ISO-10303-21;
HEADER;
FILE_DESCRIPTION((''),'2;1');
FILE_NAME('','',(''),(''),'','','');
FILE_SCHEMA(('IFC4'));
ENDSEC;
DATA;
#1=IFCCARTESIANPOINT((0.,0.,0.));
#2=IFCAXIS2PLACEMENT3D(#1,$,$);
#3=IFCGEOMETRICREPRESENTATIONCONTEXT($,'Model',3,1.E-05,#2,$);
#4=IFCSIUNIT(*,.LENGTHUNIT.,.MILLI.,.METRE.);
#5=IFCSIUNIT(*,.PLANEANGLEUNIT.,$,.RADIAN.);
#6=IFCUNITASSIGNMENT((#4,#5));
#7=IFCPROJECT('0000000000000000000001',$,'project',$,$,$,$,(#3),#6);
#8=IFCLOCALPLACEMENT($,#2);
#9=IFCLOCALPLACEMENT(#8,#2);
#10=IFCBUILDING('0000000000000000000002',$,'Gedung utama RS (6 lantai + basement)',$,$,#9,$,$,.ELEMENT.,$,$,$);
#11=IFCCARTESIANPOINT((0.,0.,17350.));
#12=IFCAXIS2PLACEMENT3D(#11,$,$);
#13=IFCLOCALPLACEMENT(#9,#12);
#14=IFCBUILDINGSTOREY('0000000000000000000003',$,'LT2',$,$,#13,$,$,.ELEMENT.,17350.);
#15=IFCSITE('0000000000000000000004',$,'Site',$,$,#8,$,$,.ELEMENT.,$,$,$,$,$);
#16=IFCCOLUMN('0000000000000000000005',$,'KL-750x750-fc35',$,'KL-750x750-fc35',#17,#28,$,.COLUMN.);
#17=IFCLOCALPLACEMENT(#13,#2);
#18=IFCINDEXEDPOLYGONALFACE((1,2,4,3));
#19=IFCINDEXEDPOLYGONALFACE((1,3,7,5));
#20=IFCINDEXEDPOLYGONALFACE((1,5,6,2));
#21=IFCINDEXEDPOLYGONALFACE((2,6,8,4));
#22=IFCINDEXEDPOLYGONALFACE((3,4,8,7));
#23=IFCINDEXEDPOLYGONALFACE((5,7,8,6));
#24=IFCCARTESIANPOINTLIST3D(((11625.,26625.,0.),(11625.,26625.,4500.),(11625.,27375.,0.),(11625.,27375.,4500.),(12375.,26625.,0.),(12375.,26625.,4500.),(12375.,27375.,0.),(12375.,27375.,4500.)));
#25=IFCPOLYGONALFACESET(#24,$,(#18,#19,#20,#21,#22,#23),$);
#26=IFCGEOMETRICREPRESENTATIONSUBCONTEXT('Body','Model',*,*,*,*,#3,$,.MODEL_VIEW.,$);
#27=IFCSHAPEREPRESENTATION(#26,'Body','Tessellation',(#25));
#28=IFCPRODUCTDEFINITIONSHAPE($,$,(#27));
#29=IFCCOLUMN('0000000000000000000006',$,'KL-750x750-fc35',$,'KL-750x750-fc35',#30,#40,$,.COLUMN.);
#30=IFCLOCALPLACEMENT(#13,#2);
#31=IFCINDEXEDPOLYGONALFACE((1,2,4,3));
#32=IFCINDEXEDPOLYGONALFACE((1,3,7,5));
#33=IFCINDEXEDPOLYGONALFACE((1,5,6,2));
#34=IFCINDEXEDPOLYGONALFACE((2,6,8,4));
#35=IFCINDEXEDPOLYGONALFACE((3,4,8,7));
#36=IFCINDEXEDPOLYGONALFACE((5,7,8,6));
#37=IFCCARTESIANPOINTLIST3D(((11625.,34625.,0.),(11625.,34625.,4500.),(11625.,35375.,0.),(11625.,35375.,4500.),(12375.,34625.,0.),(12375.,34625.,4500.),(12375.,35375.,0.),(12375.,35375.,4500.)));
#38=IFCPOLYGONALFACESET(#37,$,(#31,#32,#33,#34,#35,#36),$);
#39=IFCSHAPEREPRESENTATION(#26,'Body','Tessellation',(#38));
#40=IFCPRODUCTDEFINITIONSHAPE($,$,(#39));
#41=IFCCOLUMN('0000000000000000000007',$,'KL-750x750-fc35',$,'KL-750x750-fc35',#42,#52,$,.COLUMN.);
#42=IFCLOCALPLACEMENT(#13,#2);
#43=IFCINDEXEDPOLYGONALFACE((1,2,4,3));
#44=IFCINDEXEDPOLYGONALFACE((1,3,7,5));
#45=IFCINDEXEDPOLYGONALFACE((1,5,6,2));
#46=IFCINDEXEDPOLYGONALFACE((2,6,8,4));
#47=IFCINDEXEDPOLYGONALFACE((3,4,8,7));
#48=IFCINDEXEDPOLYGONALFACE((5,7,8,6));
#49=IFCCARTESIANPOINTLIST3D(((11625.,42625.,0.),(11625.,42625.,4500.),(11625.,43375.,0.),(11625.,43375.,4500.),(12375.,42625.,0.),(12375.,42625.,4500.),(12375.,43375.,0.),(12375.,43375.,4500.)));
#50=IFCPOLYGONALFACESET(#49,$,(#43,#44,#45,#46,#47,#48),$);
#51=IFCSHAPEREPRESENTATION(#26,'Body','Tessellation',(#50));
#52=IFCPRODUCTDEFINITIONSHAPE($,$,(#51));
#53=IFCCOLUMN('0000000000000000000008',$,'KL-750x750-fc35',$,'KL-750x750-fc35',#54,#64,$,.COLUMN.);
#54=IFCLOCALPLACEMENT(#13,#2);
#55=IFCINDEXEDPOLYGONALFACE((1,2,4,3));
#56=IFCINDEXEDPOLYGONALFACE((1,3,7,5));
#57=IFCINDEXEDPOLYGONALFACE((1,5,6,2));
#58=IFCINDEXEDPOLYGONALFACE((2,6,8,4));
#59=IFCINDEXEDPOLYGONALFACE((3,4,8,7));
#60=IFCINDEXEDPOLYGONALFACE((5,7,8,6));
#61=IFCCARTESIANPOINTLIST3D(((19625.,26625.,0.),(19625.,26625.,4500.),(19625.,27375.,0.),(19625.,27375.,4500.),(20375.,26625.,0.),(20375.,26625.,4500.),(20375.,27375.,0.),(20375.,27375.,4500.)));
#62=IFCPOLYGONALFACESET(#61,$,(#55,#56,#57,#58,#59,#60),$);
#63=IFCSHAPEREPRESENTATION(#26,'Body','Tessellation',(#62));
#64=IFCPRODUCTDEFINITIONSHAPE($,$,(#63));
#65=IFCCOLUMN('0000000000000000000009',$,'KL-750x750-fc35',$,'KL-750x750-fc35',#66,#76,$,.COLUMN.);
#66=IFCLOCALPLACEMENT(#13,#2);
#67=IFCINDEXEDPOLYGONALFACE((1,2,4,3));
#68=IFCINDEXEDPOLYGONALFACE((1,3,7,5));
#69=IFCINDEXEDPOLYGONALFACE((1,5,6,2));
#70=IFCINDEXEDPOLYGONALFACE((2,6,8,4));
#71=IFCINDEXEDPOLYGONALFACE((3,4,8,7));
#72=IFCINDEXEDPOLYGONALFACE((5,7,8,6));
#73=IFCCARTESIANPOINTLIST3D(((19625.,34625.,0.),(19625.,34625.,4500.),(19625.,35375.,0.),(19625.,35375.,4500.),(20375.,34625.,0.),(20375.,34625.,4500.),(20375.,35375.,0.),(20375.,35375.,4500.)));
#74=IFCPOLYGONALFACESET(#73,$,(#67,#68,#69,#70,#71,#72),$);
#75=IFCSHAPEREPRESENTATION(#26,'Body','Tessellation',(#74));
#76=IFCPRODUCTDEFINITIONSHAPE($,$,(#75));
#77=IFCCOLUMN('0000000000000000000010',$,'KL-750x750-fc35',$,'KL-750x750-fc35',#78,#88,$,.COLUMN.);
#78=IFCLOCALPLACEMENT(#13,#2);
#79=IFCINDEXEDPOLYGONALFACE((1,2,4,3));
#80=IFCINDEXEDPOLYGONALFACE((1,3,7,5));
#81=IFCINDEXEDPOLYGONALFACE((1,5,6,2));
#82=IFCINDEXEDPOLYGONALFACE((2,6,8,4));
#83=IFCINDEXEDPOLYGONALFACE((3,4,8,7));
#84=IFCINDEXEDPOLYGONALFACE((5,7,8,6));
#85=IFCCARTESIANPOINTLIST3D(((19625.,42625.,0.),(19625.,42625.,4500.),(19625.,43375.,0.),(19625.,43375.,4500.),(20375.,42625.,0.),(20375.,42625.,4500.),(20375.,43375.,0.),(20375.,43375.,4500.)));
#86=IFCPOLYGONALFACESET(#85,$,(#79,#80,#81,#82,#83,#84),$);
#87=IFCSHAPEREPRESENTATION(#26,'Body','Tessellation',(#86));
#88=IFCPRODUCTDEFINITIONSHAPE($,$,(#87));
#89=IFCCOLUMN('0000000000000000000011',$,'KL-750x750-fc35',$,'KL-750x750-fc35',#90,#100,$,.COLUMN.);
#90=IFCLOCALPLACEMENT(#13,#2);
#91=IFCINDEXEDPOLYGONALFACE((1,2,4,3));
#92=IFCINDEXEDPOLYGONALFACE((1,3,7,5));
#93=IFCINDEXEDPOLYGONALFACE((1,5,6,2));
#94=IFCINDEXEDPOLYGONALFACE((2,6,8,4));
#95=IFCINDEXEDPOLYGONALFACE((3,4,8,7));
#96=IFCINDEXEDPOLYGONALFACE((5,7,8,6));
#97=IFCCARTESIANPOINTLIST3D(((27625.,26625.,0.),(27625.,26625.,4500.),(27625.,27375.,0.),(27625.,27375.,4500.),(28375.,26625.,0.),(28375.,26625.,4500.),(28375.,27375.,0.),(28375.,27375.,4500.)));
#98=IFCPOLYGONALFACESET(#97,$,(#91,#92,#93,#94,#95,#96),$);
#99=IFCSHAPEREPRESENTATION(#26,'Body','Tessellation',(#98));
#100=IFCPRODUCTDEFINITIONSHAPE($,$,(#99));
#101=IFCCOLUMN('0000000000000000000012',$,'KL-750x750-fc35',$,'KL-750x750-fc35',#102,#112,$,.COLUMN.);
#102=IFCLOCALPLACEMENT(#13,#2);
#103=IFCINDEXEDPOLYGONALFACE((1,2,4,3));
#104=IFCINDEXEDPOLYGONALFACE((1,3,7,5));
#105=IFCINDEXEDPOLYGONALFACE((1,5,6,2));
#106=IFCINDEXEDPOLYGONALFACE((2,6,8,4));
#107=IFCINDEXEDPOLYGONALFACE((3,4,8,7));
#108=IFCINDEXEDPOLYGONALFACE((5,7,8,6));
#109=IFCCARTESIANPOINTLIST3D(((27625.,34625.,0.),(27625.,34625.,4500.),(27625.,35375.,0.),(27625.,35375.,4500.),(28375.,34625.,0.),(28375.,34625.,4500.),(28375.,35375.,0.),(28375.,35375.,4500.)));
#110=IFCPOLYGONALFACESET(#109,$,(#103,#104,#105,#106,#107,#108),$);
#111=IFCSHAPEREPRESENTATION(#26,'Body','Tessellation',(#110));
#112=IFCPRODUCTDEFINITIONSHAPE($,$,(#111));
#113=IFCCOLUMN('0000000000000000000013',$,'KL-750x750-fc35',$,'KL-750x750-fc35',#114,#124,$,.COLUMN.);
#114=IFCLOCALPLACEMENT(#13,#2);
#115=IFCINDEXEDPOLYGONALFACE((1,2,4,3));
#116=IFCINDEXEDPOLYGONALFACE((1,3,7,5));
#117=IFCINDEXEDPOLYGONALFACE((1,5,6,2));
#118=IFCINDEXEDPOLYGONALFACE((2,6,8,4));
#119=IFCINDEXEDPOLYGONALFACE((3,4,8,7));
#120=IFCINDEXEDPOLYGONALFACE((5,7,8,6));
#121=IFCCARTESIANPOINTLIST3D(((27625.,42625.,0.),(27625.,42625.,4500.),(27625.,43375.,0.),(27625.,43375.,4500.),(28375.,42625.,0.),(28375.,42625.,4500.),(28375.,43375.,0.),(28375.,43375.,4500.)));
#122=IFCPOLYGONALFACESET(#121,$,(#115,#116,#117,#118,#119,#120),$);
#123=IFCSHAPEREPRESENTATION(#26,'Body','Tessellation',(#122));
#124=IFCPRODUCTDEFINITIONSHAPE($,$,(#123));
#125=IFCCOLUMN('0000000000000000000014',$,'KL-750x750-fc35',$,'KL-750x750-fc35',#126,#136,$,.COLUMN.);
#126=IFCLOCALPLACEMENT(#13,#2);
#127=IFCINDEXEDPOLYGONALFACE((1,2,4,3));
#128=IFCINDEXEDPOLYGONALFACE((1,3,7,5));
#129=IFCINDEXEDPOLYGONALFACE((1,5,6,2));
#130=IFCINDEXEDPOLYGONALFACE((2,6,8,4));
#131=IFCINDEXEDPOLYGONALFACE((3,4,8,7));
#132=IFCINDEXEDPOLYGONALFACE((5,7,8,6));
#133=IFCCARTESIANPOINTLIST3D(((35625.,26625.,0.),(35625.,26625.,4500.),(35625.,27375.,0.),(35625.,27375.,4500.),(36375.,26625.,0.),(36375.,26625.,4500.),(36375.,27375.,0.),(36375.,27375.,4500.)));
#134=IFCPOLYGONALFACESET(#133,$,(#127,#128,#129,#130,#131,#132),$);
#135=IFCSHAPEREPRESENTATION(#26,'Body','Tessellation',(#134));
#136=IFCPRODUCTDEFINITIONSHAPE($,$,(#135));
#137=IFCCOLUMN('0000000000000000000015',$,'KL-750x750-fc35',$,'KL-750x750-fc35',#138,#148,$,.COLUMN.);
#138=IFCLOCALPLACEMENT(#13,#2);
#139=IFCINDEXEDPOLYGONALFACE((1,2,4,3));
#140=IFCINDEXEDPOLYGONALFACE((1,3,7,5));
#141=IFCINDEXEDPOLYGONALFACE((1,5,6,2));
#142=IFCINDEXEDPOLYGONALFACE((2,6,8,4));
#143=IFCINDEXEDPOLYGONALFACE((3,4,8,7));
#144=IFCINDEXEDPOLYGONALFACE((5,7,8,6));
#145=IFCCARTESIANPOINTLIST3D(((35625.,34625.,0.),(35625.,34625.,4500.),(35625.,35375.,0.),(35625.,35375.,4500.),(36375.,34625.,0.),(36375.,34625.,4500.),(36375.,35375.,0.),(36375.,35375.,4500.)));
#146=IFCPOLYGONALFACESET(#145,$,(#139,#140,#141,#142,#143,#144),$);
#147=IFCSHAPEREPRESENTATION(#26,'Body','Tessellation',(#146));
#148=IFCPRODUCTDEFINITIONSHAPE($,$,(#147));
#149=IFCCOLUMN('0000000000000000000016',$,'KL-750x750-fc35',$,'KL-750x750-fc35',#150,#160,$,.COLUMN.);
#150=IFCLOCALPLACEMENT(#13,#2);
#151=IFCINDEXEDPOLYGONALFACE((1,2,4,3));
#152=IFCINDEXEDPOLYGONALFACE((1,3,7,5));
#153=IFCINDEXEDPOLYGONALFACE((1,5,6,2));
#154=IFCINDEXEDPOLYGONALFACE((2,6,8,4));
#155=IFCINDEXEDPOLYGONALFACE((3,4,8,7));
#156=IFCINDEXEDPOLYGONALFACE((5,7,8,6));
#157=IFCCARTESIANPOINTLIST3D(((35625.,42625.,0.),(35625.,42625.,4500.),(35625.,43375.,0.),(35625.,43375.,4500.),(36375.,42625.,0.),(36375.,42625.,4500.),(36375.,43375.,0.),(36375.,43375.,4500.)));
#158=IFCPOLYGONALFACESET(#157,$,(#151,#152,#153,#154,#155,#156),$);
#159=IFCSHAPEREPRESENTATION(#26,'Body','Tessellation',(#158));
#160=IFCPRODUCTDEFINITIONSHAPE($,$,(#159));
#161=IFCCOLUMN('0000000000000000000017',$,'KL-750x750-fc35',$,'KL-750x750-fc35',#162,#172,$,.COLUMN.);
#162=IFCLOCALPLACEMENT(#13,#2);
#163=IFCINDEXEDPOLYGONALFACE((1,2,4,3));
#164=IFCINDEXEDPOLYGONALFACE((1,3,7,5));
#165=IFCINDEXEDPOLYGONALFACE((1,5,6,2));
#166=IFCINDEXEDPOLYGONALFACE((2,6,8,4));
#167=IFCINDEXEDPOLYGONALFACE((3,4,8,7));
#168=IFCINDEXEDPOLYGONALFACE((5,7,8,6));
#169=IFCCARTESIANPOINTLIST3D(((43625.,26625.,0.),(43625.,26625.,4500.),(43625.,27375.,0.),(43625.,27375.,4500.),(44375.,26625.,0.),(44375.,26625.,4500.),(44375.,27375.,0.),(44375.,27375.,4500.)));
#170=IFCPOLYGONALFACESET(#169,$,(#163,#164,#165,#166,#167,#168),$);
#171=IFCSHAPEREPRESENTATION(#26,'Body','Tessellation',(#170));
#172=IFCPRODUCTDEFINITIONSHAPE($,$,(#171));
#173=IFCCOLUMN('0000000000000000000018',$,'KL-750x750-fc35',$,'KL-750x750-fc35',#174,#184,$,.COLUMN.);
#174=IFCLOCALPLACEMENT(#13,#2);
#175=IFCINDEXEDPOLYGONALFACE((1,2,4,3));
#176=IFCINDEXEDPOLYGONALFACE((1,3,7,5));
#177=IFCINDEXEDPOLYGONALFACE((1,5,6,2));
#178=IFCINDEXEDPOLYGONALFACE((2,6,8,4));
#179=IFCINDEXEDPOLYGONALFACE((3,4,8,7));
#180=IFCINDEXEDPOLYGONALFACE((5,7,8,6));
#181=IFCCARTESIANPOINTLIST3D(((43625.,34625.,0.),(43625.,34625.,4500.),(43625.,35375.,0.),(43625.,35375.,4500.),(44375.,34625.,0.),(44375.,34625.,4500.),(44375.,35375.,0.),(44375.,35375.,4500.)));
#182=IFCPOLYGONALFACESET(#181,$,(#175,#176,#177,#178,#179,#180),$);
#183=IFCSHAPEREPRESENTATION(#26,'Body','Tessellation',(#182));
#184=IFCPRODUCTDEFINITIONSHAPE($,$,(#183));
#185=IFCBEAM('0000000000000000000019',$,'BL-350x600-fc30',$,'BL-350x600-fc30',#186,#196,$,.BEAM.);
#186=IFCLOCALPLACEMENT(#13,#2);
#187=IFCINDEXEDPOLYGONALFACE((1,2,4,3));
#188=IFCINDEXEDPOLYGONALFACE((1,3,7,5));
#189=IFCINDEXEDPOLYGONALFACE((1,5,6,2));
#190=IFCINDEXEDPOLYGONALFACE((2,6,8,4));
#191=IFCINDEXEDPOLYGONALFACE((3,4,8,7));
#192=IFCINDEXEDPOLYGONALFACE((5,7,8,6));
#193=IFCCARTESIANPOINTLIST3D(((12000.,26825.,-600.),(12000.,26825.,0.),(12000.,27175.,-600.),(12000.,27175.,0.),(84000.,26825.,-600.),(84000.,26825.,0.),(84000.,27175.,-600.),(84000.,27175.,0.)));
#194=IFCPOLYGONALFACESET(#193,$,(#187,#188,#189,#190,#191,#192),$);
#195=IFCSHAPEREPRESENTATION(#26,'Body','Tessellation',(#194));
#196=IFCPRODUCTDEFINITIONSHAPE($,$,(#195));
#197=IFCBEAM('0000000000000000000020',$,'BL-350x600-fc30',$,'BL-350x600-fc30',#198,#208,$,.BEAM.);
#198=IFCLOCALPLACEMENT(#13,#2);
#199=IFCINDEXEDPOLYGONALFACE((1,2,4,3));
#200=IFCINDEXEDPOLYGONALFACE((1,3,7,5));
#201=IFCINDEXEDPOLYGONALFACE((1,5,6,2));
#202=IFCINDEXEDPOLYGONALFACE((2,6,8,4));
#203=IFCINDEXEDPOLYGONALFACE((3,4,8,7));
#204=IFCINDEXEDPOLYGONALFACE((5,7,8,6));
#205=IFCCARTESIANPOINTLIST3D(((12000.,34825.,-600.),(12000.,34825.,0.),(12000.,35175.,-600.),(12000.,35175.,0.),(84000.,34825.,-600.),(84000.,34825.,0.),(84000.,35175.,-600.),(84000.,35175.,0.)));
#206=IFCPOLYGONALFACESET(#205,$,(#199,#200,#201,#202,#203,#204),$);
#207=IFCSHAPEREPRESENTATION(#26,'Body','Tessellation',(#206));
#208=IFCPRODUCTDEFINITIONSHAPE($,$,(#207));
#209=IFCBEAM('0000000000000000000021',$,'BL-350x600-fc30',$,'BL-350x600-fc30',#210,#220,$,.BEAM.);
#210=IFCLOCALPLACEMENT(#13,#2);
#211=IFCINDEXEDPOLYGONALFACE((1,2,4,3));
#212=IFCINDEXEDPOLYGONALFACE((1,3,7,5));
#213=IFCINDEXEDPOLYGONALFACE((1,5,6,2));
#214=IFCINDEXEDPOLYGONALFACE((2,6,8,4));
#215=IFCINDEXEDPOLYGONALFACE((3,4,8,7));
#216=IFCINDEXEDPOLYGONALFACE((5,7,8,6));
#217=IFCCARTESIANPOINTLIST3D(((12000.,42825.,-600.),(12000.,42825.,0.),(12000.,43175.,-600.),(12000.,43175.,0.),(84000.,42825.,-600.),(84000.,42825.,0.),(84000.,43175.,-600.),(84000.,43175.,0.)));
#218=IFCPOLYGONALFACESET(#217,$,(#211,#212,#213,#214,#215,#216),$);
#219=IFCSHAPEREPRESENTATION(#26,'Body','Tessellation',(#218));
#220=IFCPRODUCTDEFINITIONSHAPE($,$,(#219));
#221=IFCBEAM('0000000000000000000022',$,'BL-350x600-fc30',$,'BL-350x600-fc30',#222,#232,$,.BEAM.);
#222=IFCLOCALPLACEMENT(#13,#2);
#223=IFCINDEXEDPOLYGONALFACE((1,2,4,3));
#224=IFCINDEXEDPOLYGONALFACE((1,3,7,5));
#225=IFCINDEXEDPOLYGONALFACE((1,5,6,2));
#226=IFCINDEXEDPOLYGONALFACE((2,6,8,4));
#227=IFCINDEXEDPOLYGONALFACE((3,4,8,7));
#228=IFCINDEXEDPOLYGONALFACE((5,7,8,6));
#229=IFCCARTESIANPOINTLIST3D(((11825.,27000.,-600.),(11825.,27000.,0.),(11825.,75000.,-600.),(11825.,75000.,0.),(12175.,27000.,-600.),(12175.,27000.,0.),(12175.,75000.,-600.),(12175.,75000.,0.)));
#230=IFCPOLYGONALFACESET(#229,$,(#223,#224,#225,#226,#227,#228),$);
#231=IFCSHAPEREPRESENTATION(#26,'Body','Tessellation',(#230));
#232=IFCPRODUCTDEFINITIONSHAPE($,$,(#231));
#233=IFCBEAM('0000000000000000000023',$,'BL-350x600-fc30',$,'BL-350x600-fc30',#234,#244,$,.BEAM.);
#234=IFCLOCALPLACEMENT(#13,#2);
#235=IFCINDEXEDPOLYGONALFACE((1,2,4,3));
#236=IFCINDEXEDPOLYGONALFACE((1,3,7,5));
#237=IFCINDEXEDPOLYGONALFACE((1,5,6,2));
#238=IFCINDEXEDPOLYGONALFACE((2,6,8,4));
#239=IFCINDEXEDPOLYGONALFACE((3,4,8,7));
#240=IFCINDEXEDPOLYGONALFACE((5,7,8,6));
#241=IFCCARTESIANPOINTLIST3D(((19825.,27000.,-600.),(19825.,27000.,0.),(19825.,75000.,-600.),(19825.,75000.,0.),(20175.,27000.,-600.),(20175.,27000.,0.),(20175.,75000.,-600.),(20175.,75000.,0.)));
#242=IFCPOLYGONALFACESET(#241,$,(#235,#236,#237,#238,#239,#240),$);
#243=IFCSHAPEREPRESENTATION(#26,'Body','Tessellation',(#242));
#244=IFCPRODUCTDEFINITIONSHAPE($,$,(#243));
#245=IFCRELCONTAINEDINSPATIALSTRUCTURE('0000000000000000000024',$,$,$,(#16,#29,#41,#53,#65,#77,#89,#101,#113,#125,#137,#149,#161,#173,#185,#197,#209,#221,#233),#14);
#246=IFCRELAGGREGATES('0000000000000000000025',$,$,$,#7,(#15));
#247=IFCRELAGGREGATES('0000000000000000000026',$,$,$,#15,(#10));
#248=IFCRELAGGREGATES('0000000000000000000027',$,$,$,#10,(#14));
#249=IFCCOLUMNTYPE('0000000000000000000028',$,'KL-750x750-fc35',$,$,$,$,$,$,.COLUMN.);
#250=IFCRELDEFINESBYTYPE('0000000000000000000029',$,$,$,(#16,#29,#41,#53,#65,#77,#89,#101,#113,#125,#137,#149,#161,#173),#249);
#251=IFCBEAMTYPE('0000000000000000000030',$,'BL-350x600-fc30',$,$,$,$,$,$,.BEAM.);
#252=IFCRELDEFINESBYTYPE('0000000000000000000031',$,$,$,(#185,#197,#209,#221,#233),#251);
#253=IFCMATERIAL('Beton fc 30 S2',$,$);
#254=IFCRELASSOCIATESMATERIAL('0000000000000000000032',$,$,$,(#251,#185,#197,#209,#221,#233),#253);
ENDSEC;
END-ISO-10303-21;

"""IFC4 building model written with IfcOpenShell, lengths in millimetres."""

from ifc_helpers import new_model, si_unit, frame, origin, origin_2d, place, context, subcontext, project, spatial, rectangle, extrude, material, material_profile, profile_set, profile_usage, type_object, element, save


model = new_model("IFC4")

# Units and contexts
model_context = context("Model", 3, precision=1e-05, world=origin())
body_context = subcontext(model_context, "Body", "Model", "MODEL_VIEW")
ifc_project = project(units=[si_unit("LENGTHUNIT", "METRE", prefix="MILLI"), si_unit("PLANEANGLEUNIT", "RADIAN")], contexts=[model_context])

# Site, building, storey
site_placement = place(None, origin())
site = spatial("IfcSite", under=ifc_project, at=site_placement, Name="Site", CompositionType="ELEMENT")
building_placement = place(site_placement, origin())
building = spatial("IfcBuilding", under=site, at=building_placement, Name="Gedung utama RS (6 lantai + basement)", CompositionType="ELEMENT")
storey_placement = place(building_placement, frame((0.0, 0.0, 17350.0)))
storey = spatial("IfcBuildingStorey", under=building, at=storey_placement, Name="LT2", CompositionType="ELEMENT", Elevation=17350.0)

# Columns
ifc_material_profile_1 = material_profile(None, rectangle(XDim=750.0, YDim=750.0, at=origin_2d()), Name="KL-750x750-fc35")
ifc_profile_set_1 = profile_set([ifc_material_profile_1], Name="KL-750x750-fc35")
ifc_profile_usage_1 = profile_usage(ifc_profile_set_1, cardinal=5)
column_type = type_object("IfcColumnType", Name="KL-750x750-fc35", PredefinedType="COLUMN", material=ifc_profile_set_1)
for number, where, z_axis, x_axis, name in (
    (1, (12000.0, 27000.0, 0.0), (0.0, 0.0, 1.0), (1.0, 0.0, 0.0), "KL-750x750-fc35"),
    (2, (12000.0, 35000.0, 0.0), (0.0, 0.0, 1.0), (1.0, 0.0, 0.0), "KL-750x750-fc35"),
    (3, (12000.0, 43000.0, 0.0), (0.0, 0.0, 1.0), (1.0, 0.0, 0.0), "KL-750x750-fc35"),
    (4, (20000.0, 27000.0, 0.0), (0.0, 0.0, 1.0), (1.0, 0.0, 0.0), "KL-750x750-fc35"),
    (5, (20000.0, 35000.0, 0.0), (0.0, 0.0, 1.0), (1.0, 0.0, 0.0), "KL-750x750-fc35"),
    (6, (20000.0, 43000.0, 0.0), (0.0, 0.0, 1.0), (1.0, 0.0, 0.0), "KL-750x750-fc35"),
    (7, (28000.0, 27000.0, 0.0), (0.0, 0.0, 1.0), (1.0, 0.0, 0.0), "KL-750x750-fc35"),
    (8, (28000.0, 35000.0, 0.0), (0.0, 0.0, 1.0), (1.0, 0.0, 0.0), "KL-750x750-fc35"),
    (9, (28000.0, 43000.0, 0.0), (0.0, 0.0, 1.0), (1.0, 0.0, 0.0), "KL-750x750-fc35"),
    (10, (36000.0, 27000.0, 0.0), (0.0, 0.0, 1.0), (1.0, 0.0, 0.0), "KL-750x750-fc35"),
    (11, (36000.0, 35000.0, 0.0), (0.0, 0.0, 1.0), (1.0, 0.0, 0.0), "KL-750x750-fc35"),
    (12, (36000.0, 43000.0, 0.0), (0.0, 0.0, 1.0), (1.0, 0.0, 0.0), "KL-750x750-fc35"),
    (13, (44000.0, 27000.0, 0.0), (0.0, 0.0, 1.0), (1.0, 0.0, 0.0), "KL-750x750-fc35"),
    (14, (44000.0, 35000.0, 0.0), (0.0, 0.0, 1.0), (1.0, 0.0, 0.0), "KL-750x750-fc35"),
):
    element("IfcColumn", number, at=place(storey_placement, frame(where, z_axis=z_axis, x_axis=x_axis)), inside=storey, type_object=column_type, material=ifc_profile_usage_1, Name=name, ObjectType="KL-750x750-fc35", PredefinedType="COLUMN", context=body_context, shape_type="SweptSolid", body=[
        extrude(rectangle(XDim=750.0, YDim=750.0, at=origin_2d()), origin(), (0.0, 0.0, 1.0), 4500.0),
    ])

# Beams
ifc_material = material(Name="Beton fc 30 S2")
ifc_material_profile_2 = material_profile(ifc_material, rectangle(XDim=350.0, YDim=600.0, at=origin_2d()), Name="BL-350x600-fc30")
ifc_profile_set_2 = profile_set([ifc_material_profile_2], Name="BL-350x600-fc30")
ifc_profile_usage_2 = profile_usage(ifc_profile_set_2, cardinal=8)
beam_type = type_object("IfcBeamType", Name="BL-350x600-fc30", PredefinedType="BEAM", material=ifc_profile_set_2)
for number, where, name in (
    (15, (12000.0, 27000.0, -300.0), "BL-350x600-fc30"),
    (16, (12000.0, 35000.0, -300.0), "BL-350x600-fc30"),
    (17, (12000.0, 43000.0, -300.0), "BL-350x600-fc30"),
):
    element("IfcBeam", number, at=place(storey_placement, frame(where)), inside=storey, type_object=beam_type, material=ifc_profile_usage_2, Name=name, ObjectType="BL-350x600-fc30", PredefinedType="BEAM", context=body_context, shape_type="SweptSolid", body=[
        extrude(rectangle(XDim=350.0, YDim=600.0, at=origin_2d()), frame((0.0, 0.0, 0.0), z_axis=(1.0, 0.0, 0.0), x_axis=(0.0, 1.0, 0.0)), (0.0, 0.0, 1.0), 72000.0),
    ])
for number, where, name in (
    (18, (12000.0, 27000.0, -300.0), "BL-350x600-fc30"),
    (19, (20000.0, 27000.0, -300.0), "BL-350x600-fc30"),
):
    element("IfcBeam", number, at=place(storey_placement, frame(where)), inside=storey, type_object=beam_type, material=ifc_profile_usage_2, Name=name, ObjectType="BL-350x600-fc30", PredefinedType="BEAM", context=body_context, shape_type="SweptSolid", body=[
        extrude(rectangle(XDim=350.0, YDim=600.0, at=origin_2d()), frame((0.0, 0.0, 0.0), z_axis=(0.0, 1.0, 0.0), x_axis=(-1.0, 0.0, 0.0)), (0.0, 0.0, 1.0), 48000.0),
    ])

save(model, "model.ifc")
